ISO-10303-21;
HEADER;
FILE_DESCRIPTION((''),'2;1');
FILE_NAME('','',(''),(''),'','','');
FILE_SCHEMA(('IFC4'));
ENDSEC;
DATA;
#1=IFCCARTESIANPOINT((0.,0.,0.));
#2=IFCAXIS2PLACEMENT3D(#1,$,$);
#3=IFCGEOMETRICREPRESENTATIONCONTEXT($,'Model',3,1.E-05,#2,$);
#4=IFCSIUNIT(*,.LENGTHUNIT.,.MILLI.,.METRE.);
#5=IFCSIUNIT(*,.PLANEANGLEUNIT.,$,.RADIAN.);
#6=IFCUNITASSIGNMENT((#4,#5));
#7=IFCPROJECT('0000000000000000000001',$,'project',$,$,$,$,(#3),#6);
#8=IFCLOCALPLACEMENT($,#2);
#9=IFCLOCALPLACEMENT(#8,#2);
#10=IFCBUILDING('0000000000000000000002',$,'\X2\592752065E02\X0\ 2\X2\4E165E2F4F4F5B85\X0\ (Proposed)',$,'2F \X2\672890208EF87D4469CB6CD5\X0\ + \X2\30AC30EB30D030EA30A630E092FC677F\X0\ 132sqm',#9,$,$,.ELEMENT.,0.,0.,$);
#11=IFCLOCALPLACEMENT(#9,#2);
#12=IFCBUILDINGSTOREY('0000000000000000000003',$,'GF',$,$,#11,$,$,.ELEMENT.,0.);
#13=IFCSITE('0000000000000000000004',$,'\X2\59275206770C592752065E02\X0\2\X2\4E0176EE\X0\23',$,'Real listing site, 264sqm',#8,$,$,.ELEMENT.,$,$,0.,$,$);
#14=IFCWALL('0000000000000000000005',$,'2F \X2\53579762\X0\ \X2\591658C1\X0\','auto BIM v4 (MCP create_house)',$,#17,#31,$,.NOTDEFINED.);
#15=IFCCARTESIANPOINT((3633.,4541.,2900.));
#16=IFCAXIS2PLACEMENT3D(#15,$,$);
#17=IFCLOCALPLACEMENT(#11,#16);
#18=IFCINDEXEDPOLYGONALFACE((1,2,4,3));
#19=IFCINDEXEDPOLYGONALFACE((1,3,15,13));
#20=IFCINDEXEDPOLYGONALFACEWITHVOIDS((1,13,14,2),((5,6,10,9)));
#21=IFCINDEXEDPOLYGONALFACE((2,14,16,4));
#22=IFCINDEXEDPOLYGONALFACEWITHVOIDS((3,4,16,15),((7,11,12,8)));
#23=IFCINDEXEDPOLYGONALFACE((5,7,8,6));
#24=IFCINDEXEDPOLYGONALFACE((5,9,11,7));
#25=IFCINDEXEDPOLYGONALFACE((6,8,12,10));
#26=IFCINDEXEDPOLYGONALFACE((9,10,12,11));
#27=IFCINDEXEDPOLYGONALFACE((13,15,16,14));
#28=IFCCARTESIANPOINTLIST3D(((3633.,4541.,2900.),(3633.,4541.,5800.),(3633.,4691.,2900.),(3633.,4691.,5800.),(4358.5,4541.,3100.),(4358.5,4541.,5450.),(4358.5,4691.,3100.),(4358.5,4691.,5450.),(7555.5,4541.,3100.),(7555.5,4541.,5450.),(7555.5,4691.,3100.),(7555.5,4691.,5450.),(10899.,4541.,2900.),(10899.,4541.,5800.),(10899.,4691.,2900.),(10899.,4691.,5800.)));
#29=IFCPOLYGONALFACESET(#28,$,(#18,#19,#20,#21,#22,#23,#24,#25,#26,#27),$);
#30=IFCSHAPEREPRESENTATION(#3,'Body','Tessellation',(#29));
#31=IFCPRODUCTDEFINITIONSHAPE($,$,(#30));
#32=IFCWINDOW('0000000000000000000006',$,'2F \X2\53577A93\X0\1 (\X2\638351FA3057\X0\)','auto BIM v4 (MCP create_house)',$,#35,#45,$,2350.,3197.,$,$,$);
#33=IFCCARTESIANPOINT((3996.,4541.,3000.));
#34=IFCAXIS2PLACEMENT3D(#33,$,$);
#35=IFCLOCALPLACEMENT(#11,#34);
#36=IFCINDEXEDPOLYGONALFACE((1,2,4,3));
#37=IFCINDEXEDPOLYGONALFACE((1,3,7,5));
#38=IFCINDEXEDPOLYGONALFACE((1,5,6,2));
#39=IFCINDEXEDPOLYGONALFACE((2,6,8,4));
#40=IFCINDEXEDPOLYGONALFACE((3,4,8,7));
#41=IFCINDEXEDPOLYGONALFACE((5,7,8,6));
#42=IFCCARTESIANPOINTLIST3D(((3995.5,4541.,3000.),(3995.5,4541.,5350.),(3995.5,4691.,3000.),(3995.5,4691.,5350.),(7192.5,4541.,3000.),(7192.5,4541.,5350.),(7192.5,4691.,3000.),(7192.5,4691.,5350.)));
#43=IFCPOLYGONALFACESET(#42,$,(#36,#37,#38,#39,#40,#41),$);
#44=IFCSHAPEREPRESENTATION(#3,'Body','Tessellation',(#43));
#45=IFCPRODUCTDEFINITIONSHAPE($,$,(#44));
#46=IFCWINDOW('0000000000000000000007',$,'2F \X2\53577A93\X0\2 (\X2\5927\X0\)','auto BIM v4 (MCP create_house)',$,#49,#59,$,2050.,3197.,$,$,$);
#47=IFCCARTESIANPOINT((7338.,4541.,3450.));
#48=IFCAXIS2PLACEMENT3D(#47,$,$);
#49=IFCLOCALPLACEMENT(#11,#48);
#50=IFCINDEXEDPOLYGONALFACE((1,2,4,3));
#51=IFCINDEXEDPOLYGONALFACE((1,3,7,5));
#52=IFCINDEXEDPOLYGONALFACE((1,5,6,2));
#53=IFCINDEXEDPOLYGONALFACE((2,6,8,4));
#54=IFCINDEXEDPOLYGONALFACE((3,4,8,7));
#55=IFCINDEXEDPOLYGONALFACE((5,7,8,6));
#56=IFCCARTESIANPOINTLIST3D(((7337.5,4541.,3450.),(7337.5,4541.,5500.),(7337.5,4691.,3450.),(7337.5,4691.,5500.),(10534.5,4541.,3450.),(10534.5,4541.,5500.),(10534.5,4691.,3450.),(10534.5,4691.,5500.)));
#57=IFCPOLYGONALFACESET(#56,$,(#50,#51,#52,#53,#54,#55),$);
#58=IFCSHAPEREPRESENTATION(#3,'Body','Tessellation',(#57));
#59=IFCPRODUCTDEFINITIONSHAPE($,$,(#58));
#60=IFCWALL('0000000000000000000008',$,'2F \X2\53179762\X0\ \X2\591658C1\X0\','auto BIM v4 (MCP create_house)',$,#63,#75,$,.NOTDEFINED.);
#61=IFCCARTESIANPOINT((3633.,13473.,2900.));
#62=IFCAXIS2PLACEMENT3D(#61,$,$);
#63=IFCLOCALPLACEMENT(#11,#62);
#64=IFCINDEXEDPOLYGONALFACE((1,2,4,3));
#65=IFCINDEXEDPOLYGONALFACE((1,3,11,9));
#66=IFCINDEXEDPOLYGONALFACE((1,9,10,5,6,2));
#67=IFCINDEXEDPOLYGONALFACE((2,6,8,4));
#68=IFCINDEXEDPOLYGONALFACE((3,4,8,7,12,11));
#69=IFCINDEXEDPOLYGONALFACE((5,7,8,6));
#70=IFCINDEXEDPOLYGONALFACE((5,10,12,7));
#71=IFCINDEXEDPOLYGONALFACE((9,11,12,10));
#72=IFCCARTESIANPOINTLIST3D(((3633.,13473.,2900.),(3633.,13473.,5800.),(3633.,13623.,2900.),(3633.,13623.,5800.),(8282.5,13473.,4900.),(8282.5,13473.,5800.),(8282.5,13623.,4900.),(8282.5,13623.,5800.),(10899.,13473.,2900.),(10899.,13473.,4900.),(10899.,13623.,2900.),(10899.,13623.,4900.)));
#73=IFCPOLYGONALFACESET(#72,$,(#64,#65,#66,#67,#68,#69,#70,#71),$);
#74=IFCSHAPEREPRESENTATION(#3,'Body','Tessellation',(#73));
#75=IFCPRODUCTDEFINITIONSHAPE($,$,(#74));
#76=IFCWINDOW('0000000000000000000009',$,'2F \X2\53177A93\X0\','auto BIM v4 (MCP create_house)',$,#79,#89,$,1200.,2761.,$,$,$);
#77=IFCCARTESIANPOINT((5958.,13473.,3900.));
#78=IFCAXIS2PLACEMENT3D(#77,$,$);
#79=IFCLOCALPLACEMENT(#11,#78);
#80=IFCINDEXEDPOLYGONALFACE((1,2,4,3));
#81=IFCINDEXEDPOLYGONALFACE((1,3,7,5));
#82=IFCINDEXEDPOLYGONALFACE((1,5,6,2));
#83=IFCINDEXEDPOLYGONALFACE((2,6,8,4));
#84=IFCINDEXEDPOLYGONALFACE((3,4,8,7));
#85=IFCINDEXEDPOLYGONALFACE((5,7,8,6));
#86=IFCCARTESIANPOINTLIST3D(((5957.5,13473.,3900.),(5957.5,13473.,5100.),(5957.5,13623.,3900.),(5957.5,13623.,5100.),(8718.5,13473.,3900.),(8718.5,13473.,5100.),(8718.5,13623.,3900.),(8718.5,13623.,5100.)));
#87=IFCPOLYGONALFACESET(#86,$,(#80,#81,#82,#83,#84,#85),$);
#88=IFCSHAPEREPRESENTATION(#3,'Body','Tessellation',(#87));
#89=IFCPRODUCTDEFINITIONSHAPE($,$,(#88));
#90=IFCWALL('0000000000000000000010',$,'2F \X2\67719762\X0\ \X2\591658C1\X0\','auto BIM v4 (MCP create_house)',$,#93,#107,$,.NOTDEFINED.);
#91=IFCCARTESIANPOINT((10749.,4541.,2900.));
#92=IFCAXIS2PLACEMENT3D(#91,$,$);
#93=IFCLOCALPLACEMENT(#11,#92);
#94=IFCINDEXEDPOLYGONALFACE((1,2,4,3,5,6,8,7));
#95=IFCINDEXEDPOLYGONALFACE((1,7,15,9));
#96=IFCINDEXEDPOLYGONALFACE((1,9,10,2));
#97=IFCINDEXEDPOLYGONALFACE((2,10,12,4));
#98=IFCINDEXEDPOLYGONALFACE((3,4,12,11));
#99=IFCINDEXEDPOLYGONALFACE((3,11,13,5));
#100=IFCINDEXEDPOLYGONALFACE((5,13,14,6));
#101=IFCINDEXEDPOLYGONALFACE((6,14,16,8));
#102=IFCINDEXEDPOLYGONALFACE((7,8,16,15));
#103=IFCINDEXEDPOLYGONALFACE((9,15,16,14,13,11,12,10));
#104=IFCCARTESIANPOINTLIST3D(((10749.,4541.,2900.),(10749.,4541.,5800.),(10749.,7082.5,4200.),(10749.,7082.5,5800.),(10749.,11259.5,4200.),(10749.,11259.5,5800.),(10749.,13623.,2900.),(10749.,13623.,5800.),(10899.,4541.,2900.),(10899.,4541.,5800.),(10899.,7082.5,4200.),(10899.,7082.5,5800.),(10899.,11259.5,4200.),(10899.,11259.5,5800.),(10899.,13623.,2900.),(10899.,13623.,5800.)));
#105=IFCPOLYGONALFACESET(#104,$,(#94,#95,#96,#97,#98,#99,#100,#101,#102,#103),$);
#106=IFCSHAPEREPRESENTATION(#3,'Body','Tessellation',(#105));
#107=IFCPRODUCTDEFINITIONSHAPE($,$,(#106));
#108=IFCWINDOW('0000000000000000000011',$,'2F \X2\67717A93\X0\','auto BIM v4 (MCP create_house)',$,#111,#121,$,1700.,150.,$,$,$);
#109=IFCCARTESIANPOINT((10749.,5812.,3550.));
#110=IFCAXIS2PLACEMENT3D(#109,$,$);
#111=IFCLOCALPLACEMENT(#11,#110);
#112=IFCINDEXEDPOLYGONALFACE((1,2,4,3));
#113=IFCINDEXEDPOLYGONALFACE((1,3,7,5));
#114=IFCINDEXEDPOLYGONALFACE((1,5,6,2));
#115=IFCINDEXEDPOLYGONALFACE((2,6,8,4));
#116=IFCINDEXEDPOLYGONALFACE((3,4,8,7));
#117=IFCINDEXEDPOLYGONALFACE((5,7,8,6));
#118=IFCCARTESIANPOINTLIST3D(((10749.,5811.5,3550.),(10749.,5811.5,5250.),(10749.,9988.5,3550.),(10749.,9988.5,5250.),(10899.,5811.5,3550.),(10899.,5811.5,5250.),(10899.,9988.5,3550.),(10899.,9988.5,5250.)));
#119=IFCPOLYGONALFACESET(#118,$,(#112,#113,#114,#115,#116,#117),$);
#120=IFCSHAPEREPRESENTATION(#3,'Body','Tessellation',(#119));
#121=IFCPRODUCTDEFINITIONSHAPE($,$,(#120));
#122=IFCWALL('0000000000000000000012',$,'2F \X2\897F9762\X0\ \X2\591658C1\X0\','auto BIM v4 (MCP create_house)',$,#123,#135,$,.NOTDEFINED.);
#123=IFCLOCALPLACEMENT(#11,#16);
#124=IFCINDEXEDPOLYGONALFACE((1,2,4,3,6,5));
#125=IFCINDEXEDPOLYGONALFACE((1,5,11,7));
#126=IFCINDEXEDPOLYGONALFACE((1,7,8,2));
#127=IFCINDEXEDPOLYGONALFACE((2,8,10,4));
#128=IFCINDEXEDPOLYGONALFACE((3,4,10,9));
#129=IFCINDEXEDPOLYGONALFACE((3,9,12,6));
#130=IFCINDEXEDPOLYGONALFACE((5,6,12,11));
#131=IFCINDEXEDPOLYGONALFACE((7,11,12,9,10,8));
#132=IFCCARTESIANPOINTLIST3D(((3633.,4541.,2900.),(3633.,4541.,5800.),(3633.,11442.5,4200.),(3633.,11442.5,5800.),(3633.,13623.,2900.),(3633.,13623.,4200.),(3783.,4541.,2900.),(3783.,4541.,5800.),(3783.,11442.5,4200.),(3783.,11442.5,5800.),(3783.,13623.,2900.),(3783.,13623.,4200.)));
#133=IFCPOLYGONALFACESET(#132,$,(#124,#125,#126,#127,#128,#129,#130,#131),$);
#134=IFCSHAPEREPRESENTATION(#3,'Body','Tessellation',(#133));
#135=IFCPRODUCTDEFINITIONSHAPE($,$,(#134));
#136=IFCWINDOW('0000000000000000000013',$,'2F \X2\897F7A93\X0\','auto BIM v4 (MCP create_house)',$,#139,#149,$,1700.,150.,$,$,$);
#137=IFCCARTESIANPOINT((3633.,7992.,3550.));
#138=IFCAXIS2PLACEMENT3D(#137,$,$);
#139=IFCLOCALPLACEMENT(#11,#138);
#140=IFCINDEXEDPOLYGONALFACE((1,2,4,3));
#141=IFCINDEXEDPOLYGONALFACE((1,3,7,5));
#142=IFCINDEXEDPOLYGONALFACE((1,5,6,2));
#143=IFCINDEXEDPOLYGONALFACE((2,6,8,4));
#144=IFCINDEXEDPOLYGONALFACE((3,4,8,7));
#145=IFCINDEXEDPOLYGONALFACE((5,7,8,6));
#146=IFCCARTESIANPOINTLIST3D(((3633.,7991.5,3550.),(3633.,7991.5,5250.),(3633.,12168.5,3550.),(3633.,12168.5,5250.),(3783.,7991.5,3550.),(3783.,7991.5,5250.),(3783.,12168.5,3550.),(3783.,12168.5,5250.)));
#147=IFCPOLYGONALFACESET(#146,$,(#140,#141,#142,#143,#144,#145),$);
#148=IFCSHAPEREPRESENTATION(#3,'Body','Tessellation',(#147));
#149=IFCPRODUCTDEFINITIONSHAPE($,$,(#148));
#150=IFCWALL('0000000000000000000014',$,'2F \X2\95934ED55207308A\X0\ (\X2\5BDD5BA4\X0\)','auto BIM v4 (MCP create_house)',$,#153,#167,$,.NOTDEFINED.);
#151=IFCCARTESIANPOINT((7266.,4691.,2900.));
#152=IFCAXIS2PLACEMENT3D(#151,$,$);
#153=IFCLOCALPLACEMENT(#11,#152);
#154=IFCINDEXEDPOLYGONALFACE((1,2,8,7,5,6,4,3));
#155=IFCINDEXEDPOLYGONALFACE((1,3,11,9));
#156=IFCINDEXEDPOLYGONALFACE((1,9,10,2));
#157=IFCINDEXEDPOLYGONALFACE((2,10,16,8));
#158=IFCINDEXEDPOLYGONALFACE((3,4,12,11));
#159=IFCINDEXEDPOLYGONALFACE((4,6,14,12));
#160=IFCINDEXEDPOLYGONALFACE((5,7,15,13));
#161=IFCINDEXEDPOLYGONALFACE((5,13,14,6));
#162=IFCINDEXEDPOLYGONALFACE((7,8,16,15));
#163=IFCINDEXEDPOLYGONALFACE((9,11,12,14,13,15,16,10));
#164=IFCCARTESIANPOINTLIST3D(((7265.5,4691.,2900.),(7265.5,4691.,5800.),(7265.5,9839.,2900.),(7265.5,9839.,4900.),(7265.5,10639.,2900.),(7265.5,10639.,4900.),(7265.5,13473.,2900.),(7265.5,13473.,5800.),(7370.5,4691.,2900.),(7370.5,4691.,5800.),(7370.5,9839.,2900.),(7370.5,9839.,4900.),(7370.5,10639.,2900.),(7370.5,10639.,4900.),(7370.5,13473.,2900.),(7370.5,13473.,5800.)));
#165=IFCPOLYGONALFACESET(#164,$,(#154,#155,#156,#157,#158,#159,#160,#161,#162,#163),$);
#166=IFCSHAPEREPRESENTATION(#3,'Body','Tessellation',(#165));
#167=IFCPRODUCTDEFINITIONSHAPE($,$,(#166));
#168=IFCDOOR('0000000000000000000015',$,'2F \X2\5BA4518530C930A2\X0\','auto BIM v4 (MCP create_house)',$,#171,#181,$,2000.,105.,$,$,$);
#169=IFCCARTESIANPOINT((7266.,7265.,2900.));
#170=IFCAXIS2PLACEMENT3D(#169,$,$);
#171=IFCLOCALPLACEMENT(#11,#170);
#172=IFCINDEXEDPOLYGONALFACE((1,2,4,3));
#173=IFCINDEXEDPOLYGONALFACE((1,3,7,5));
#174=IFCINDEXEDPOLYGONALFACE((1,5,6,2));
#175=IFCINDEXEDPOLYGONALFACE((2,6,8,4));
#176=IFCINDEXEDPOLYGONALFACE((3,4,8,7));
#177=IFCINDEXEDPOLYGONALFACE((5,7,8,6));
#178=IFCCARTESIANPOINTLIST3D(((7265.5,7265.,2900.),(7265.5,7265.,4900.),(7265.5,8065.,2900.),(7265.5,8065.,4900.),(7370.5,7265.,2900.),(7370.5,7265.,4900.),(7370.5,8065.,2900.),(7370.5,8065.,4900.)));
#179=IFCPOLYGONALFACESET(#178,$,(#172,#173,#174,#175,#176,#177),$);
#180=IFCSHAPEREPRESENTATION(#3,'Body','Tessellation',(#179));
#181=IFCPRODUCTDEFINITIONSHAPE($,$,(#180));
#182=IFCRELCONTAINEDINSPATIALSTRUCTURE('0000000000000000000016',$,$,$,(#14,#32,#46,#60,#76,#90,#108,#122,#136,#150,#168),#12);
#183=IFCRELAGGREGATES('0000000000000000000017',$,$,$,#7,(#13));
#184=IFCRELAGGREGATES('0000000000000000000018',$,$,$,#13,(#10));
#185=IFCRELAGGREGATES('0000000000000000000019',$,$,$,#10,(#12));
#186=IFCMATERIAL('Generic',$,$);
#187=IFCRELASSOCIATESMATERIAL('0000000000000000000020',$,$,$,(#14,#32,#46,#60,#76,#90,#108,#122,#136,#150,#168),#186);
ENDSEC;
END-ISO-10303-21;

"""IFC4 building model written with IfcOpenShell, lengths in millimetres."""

from ifc_helpers import new_model, si_unit, frame, frame_2d, origin, place, context, project, spatial, rectangle, extrude, material, element, fill, save


model = new_model("IFC4")

# Units and contexts
model_context = context("Model", 3, precision=1e-05, world=origin())
ifc_project = project(units=[si_unit("LENGTHUNIT", "METRE", prefix="MILLI"), si_unit("PLANEANGLEUNIT", "RADIAN")], contexts=[model_context])

# Site, building, storey
site_placement = place(None, origin())
site = spatial("IfcSite", under=ifc_project, at=site_placement, Name="大分県大分市2丁目23", ObjectType="Real listing site, 264sqm", CompositionType="ELEMENT", RefElevation=0.0)
building_placement = place(site_placement, origin())
building = spatial("IfcBuilding", under=site, at=building_placement, Name="大分市 2世帯住宅 (Proposed)", ObjectType="2F 木造軸組構法 + ガルバリウム鋼板 132sqm", CompositionType="ELEMENT", ElevationOfRefHeight=0.0, ElevationOfTerrain=0.0)
storey_placement = place(building_placement, origin())
storey = spatial("IfcBuildingStorey", under=building, at=storey_placement, Name="GF", CompositionType="ELEMENT", Elevation=0.0)

# Shared definitions
ifc_material = material(Name="Generic")

# Wall, openings, windows
wall_1_placement = place(storey_placement, frame((3633.0, 4541.0, 2900.0)))
wall_1 = element("IfcWall", 1, at=wall_1_placement, inside=storey, material=ifc_material, Name="2F 南面 外壁", Description="auto BIM v4 (MCP create_house)", PredefinedType="NOTDEFINED", context=model_context, shape_type="SweptSolid", body=[
    extrude(rectangle(XDim=7266.0, YDim=150.0, at=frame_2d((3633.0, 75.0))), frame((3633.0, 4541.0, 2900.0)), (0.0, 0.0, 1.0), 2900.0),
])
opening_1_placement = place(storey_placement, frame((3996.0, 4541.0, 3000.0)))
opening_1 = element("IfcOpeningElement", 2, at=opening_1_placement, cuts=wall_1, PredefinedType="NOTDEFINED", context=model_context, shape_type="SweptSolid", body=[
    extrude(rectangle(XDim=3197.0, YDim=150.0, at=frame_2d((1598.0, 75.0))), frame((3996.0, 4541.0, 3000.0)), (0.0, 0.0, 1.0), 2350.0),
])
opening_2_placement = place(storey_placement, frame((7338.0, 4541.0, 3450.0)))
opening_2 = element("IfcOpeningElement", 3, at=opening_2_placement, cuts=wall_1, PredefinedType="NOTDEFINED", context=model_context, shape_type="SweptSolid", body=[
    extrude(rectangle(XDim=3197.0, YDim=150.0, at=frame_2d((1598.0, 75.0))), frame((7338.0, 4541.0, 3450.0)), (0.0, 0.0, 1.0), 2050.0),
])
window_1_placement = place(storey_placement, frame((3996.0, 4541.0, 3000.0)))
window_1 = element("IfcWindow", 4, at=window_1_placement, inside=storey, material=ifc_material, Name="2F 南窓1 (掃出し)", Description="auto BIM v4 (MCP create_house)", OverallHeight=2350.0, OverallWidth=3197.0, context=model_context, shape_type="SweptSolid", body=[
    extrude(rectangle(XDim=3197.0, YDim=150.0, at=frame_2d((1598.0, 75.0))), frame((3996.0, 4541.0, 3000.0)), (0.0, 0.0, 1.0), 2350.0),
])
fill(opening_1, window_1)
window_2_placement = place(storey_placement, frame((7338.0, 4541.0, 3450.0)))
window_2 = element("IfcWindow", 5, at=window_2_placement, inside=storey, material=ifc_material, Name="2F 南窓2 (大)", Description="auto BIM v4 (MCP create_house)", OverallHeight=2050.0, OverallWidth=3197.0, context=model_context, shape_type="SweptSolid", body=[
    extrude(rectangle(XDim=3197.0, YDim=150.0, at=frame_2d((1598.0, 75.0))), frame((7338.0, 4541.0, 3450.0)), (0.0, 0.0, 1.0), 2050.0),
])
fill(opening_2, window_2)

# Walls, openings, windows
wall_2_placement = place(storey_placement, frame((3633.0, 13473.0, 2900.0)))
wall_2 = element("IfcWall", 6, at=wall_2_placement, inside=storey, material=ifc_material, Name="2F 北面 外壁", Description="auto BIM v4 (MCP create_house)", PredefinedType="NOTDEFINED", context=model_context, shape_type="SweptSolid", body=[
    extrude(rectangle(XDim=7266.0, YDim=150.0, at=frame_2d((3633.0, 75.0))), frame((3633.0, 13473.0, 2900.0)), (0.0, 0.0, 1.0), 2900.0),
])
opening_3_placement = place(storey_placement, frame((5958.0, 13473.0, 3900.0)))
opening_3 = element("IfcOpeningElement", 7, at=opening_3_placement, cuts=wall_2, PredefinedType="NOTDEFINED", context=model_context, shape_type="SweptSolid", body=[
    extrude(rectangle(XDim=2761.0, YDim=150.0, at=frame_2d((1380.0, 75.0))), frame((5958.0, 13473.0, 3900.0)), (0.0, 0.0, 1.0), 1200.0),
])
window_3_placement = place(storey_placement, frame((5958.0, 13473.0, 3900.0)))
window_3 = element("IfcWindow", 8, at=window_3_placement, inside=storey, material=ifc_material, Name="2F 北窓", Description="auto BIM v4 (MCP create_house)", OverallHeight=1200.0, OverallWidth=2761.0, context=model_context, shape_type="SweptSolid", body=[
    extrude(rectangle(XDim=2761.0, YDim=150.0, at=frame_2d((1380.0, 75.0))), frame((5958.0, 13473.0, 3900.0)), (0.0, 0.0, 1.0), 1200.0),
])
fill(opening_3, window_3)
wall_3_placement = place(storey_placement, frame((10749.0, 4541.0, 2900.0)))
wall_3 = element("IfcWall", 9, at=wall_3_placement, inside=storey, material=ifc_material, Name="2F 東面 外壁", Description="auto BIM v4 (MCP create_house)", PredefinedType="NOTDEFINED", context=model_context, shape_type="SweptSolid", body=[
    extrude(rectangle(XDim=150.0, YDim=9082.0, at=frame_2d((75.0, 4541.0))), frame((10749.0, 4541.0, 2900.0)), (0.0, 0.0, 1.0), 2900.0),
])
opening_4_placement = place(storey_placement, frame((10749.0, 5812.0, 3550.0)))
opening_4 = element("IfcOpeningElement", 10, at=opening_4_placement, cuts=wall_3, PredefinedType="NOTDEFINED", context=model_context, shape_type="SweptSolid", body=[
    extrude(rectangle(XDim=150.0, YDim=4177.0, at=frame_2d((75.0, 2088.0))), frame((10749.0, 5812.0, 3550.0)), (0.0, 0.0, 1.0), 1700.0),
])
window_4_placement = place(storey_placement, frame((10749.0, 5812.0, 3550.0)))
window_4 = element("IfcWindow", 11, at=window_4_placement, inside=storey, material=ifc_material, Name="2F 東窓", Description="auto BIM v4 (MCP create_house)", OverallHeight=1700.0, OverallWidth=150.0, context=model_context, shape_type="SweptSolid", body=[
    extrude(rectangle(XDim=150.0, YDim=4177.0, at=frame_2d((75.0, 2088.0))), frame((10749.0, 5812.0, 3550.0)), (0.0, 0.0, 1.0), 1700.0),
])
fill(opening_4, window_4)
wall_4_placement = place(storey_placement, frame((3633.0, 4541.0, 2900.0)))
wall_4 = element("IfcWall", 12, at=wall_4_placement, inside=storey, material=ifc_material, Name="2F 西面 外壁", Description="auto BIM v4 (MCP create_house)", PredefinedType="NOTDEFINED", context=model_context, shape_type="SweptSolid", body=[
    extrude(rectangle(XDim=150.0, YDim=9082.0, at=frame_2d((75.0, 4541.0))), frame((3633.0, 4541.0, 2900.0)), (0.0, 0.0, 1.0), 2900.0),
])
opening_5_placement = place(storey_placement, frame((3633.0, 7992.0, 3550.0)))
opening_5 = element("IfcOpeningElement", 13, at=opening_5_placement, cuts=wall_4, PredefinedType="NOTDEFINED", context=model_context, shape_type="SweptSolid", body=[
    extrude(rectangle(XDim=150.0, YDim=4177.0, at=frame_2d((75.0, 2088.0))), frame((3633.0, 7992.0, 3550.0)), (0.0, 0.0, 1.0), 1700.0),
])
window_5_placement = place(storey_placement, frame((3633.0, 7992.0, 3550.0)))
window_5 = element("IfcWindow", 14, at=window_5_placement, inside=storey, material=ifc_material, Name="2F 西窓", Description="auto BIM v4 (MCP create_house)", OverallHeight=1700.0, OverallWidth=150.0, context=model_context, shape_type="SweptSolid", body=[
    extrude(rectangle(XDim=150.0, YDim=4177.0, at=frame_2d((75.0, 2088.0))), frame((3633.0, 7992.0, 3550.0)), (0.0, 0.0, 1.0), 1700.0),
])
fill(opening_5, window_5)

# Wall, opening, door
wall_5_placement = place(storey_placement, frame((7266.0, 4691.0, 2900.0)))
wall_5 = element("IfcWall", 15, at=wall_5_placement, inside=storey, material=ifc_material, Name="2F 間仕切り (寝室)", Description="auto BIM v4 (MCP create_house)", PredefinedType="NOTDEFINED", context=model_context, shape_type="SweptSolid", body=[
    extrude(rectangle(XDim=105.0, YDim=8782.0, at=frame_2d((52.0, 4391.0))), frame((7266.0, 4691.0, 2900.0)), (0.0, 0.0, 1.0), 2900.0),
])
opening_6_placement = place(storey_placement, frame((7266.0, 7265.0, 2900.0)))
opening_6 = element("IfcOpeningElement", 16, at=opening_6_placement, cuts=wall_5, PredefinedType="NOTDEFINED", context=model_context, shape_type="SweptSolid", body=[
    extrude(rectangle(XDim=105.0, YDim=800.0, at=frame_2d((52.0, 400.0))), frame((7266.0, 7265.0, 2900.0)), (0.0, 0.0, 1.0), 2000.0),
])
door_1_placement = place(storey_placement, frame((7266.0, 7265.0, 2900.0)))
door_1 = element("IfcDoor", 17, at=door_1_placement, inside=storey, material=ifc_material, Name="2F 室内ドア", Description="auto BIM v4 (MCP create_house)", OverallHeight=2000.0, OverallWidth=105.0, context=model_context, shape_type="SweptSolid", body=[
    extrude(rectangle(XDim=105.0, YDim=800.0, at=frame_2d((52.0, 400.0))), frame((7266.0, 7265.0, 2900.0)), (0.0, 0.0, 1.0), 2000.0),
])
fill(opening_6, door_1)

save(model, "model.ifc")
